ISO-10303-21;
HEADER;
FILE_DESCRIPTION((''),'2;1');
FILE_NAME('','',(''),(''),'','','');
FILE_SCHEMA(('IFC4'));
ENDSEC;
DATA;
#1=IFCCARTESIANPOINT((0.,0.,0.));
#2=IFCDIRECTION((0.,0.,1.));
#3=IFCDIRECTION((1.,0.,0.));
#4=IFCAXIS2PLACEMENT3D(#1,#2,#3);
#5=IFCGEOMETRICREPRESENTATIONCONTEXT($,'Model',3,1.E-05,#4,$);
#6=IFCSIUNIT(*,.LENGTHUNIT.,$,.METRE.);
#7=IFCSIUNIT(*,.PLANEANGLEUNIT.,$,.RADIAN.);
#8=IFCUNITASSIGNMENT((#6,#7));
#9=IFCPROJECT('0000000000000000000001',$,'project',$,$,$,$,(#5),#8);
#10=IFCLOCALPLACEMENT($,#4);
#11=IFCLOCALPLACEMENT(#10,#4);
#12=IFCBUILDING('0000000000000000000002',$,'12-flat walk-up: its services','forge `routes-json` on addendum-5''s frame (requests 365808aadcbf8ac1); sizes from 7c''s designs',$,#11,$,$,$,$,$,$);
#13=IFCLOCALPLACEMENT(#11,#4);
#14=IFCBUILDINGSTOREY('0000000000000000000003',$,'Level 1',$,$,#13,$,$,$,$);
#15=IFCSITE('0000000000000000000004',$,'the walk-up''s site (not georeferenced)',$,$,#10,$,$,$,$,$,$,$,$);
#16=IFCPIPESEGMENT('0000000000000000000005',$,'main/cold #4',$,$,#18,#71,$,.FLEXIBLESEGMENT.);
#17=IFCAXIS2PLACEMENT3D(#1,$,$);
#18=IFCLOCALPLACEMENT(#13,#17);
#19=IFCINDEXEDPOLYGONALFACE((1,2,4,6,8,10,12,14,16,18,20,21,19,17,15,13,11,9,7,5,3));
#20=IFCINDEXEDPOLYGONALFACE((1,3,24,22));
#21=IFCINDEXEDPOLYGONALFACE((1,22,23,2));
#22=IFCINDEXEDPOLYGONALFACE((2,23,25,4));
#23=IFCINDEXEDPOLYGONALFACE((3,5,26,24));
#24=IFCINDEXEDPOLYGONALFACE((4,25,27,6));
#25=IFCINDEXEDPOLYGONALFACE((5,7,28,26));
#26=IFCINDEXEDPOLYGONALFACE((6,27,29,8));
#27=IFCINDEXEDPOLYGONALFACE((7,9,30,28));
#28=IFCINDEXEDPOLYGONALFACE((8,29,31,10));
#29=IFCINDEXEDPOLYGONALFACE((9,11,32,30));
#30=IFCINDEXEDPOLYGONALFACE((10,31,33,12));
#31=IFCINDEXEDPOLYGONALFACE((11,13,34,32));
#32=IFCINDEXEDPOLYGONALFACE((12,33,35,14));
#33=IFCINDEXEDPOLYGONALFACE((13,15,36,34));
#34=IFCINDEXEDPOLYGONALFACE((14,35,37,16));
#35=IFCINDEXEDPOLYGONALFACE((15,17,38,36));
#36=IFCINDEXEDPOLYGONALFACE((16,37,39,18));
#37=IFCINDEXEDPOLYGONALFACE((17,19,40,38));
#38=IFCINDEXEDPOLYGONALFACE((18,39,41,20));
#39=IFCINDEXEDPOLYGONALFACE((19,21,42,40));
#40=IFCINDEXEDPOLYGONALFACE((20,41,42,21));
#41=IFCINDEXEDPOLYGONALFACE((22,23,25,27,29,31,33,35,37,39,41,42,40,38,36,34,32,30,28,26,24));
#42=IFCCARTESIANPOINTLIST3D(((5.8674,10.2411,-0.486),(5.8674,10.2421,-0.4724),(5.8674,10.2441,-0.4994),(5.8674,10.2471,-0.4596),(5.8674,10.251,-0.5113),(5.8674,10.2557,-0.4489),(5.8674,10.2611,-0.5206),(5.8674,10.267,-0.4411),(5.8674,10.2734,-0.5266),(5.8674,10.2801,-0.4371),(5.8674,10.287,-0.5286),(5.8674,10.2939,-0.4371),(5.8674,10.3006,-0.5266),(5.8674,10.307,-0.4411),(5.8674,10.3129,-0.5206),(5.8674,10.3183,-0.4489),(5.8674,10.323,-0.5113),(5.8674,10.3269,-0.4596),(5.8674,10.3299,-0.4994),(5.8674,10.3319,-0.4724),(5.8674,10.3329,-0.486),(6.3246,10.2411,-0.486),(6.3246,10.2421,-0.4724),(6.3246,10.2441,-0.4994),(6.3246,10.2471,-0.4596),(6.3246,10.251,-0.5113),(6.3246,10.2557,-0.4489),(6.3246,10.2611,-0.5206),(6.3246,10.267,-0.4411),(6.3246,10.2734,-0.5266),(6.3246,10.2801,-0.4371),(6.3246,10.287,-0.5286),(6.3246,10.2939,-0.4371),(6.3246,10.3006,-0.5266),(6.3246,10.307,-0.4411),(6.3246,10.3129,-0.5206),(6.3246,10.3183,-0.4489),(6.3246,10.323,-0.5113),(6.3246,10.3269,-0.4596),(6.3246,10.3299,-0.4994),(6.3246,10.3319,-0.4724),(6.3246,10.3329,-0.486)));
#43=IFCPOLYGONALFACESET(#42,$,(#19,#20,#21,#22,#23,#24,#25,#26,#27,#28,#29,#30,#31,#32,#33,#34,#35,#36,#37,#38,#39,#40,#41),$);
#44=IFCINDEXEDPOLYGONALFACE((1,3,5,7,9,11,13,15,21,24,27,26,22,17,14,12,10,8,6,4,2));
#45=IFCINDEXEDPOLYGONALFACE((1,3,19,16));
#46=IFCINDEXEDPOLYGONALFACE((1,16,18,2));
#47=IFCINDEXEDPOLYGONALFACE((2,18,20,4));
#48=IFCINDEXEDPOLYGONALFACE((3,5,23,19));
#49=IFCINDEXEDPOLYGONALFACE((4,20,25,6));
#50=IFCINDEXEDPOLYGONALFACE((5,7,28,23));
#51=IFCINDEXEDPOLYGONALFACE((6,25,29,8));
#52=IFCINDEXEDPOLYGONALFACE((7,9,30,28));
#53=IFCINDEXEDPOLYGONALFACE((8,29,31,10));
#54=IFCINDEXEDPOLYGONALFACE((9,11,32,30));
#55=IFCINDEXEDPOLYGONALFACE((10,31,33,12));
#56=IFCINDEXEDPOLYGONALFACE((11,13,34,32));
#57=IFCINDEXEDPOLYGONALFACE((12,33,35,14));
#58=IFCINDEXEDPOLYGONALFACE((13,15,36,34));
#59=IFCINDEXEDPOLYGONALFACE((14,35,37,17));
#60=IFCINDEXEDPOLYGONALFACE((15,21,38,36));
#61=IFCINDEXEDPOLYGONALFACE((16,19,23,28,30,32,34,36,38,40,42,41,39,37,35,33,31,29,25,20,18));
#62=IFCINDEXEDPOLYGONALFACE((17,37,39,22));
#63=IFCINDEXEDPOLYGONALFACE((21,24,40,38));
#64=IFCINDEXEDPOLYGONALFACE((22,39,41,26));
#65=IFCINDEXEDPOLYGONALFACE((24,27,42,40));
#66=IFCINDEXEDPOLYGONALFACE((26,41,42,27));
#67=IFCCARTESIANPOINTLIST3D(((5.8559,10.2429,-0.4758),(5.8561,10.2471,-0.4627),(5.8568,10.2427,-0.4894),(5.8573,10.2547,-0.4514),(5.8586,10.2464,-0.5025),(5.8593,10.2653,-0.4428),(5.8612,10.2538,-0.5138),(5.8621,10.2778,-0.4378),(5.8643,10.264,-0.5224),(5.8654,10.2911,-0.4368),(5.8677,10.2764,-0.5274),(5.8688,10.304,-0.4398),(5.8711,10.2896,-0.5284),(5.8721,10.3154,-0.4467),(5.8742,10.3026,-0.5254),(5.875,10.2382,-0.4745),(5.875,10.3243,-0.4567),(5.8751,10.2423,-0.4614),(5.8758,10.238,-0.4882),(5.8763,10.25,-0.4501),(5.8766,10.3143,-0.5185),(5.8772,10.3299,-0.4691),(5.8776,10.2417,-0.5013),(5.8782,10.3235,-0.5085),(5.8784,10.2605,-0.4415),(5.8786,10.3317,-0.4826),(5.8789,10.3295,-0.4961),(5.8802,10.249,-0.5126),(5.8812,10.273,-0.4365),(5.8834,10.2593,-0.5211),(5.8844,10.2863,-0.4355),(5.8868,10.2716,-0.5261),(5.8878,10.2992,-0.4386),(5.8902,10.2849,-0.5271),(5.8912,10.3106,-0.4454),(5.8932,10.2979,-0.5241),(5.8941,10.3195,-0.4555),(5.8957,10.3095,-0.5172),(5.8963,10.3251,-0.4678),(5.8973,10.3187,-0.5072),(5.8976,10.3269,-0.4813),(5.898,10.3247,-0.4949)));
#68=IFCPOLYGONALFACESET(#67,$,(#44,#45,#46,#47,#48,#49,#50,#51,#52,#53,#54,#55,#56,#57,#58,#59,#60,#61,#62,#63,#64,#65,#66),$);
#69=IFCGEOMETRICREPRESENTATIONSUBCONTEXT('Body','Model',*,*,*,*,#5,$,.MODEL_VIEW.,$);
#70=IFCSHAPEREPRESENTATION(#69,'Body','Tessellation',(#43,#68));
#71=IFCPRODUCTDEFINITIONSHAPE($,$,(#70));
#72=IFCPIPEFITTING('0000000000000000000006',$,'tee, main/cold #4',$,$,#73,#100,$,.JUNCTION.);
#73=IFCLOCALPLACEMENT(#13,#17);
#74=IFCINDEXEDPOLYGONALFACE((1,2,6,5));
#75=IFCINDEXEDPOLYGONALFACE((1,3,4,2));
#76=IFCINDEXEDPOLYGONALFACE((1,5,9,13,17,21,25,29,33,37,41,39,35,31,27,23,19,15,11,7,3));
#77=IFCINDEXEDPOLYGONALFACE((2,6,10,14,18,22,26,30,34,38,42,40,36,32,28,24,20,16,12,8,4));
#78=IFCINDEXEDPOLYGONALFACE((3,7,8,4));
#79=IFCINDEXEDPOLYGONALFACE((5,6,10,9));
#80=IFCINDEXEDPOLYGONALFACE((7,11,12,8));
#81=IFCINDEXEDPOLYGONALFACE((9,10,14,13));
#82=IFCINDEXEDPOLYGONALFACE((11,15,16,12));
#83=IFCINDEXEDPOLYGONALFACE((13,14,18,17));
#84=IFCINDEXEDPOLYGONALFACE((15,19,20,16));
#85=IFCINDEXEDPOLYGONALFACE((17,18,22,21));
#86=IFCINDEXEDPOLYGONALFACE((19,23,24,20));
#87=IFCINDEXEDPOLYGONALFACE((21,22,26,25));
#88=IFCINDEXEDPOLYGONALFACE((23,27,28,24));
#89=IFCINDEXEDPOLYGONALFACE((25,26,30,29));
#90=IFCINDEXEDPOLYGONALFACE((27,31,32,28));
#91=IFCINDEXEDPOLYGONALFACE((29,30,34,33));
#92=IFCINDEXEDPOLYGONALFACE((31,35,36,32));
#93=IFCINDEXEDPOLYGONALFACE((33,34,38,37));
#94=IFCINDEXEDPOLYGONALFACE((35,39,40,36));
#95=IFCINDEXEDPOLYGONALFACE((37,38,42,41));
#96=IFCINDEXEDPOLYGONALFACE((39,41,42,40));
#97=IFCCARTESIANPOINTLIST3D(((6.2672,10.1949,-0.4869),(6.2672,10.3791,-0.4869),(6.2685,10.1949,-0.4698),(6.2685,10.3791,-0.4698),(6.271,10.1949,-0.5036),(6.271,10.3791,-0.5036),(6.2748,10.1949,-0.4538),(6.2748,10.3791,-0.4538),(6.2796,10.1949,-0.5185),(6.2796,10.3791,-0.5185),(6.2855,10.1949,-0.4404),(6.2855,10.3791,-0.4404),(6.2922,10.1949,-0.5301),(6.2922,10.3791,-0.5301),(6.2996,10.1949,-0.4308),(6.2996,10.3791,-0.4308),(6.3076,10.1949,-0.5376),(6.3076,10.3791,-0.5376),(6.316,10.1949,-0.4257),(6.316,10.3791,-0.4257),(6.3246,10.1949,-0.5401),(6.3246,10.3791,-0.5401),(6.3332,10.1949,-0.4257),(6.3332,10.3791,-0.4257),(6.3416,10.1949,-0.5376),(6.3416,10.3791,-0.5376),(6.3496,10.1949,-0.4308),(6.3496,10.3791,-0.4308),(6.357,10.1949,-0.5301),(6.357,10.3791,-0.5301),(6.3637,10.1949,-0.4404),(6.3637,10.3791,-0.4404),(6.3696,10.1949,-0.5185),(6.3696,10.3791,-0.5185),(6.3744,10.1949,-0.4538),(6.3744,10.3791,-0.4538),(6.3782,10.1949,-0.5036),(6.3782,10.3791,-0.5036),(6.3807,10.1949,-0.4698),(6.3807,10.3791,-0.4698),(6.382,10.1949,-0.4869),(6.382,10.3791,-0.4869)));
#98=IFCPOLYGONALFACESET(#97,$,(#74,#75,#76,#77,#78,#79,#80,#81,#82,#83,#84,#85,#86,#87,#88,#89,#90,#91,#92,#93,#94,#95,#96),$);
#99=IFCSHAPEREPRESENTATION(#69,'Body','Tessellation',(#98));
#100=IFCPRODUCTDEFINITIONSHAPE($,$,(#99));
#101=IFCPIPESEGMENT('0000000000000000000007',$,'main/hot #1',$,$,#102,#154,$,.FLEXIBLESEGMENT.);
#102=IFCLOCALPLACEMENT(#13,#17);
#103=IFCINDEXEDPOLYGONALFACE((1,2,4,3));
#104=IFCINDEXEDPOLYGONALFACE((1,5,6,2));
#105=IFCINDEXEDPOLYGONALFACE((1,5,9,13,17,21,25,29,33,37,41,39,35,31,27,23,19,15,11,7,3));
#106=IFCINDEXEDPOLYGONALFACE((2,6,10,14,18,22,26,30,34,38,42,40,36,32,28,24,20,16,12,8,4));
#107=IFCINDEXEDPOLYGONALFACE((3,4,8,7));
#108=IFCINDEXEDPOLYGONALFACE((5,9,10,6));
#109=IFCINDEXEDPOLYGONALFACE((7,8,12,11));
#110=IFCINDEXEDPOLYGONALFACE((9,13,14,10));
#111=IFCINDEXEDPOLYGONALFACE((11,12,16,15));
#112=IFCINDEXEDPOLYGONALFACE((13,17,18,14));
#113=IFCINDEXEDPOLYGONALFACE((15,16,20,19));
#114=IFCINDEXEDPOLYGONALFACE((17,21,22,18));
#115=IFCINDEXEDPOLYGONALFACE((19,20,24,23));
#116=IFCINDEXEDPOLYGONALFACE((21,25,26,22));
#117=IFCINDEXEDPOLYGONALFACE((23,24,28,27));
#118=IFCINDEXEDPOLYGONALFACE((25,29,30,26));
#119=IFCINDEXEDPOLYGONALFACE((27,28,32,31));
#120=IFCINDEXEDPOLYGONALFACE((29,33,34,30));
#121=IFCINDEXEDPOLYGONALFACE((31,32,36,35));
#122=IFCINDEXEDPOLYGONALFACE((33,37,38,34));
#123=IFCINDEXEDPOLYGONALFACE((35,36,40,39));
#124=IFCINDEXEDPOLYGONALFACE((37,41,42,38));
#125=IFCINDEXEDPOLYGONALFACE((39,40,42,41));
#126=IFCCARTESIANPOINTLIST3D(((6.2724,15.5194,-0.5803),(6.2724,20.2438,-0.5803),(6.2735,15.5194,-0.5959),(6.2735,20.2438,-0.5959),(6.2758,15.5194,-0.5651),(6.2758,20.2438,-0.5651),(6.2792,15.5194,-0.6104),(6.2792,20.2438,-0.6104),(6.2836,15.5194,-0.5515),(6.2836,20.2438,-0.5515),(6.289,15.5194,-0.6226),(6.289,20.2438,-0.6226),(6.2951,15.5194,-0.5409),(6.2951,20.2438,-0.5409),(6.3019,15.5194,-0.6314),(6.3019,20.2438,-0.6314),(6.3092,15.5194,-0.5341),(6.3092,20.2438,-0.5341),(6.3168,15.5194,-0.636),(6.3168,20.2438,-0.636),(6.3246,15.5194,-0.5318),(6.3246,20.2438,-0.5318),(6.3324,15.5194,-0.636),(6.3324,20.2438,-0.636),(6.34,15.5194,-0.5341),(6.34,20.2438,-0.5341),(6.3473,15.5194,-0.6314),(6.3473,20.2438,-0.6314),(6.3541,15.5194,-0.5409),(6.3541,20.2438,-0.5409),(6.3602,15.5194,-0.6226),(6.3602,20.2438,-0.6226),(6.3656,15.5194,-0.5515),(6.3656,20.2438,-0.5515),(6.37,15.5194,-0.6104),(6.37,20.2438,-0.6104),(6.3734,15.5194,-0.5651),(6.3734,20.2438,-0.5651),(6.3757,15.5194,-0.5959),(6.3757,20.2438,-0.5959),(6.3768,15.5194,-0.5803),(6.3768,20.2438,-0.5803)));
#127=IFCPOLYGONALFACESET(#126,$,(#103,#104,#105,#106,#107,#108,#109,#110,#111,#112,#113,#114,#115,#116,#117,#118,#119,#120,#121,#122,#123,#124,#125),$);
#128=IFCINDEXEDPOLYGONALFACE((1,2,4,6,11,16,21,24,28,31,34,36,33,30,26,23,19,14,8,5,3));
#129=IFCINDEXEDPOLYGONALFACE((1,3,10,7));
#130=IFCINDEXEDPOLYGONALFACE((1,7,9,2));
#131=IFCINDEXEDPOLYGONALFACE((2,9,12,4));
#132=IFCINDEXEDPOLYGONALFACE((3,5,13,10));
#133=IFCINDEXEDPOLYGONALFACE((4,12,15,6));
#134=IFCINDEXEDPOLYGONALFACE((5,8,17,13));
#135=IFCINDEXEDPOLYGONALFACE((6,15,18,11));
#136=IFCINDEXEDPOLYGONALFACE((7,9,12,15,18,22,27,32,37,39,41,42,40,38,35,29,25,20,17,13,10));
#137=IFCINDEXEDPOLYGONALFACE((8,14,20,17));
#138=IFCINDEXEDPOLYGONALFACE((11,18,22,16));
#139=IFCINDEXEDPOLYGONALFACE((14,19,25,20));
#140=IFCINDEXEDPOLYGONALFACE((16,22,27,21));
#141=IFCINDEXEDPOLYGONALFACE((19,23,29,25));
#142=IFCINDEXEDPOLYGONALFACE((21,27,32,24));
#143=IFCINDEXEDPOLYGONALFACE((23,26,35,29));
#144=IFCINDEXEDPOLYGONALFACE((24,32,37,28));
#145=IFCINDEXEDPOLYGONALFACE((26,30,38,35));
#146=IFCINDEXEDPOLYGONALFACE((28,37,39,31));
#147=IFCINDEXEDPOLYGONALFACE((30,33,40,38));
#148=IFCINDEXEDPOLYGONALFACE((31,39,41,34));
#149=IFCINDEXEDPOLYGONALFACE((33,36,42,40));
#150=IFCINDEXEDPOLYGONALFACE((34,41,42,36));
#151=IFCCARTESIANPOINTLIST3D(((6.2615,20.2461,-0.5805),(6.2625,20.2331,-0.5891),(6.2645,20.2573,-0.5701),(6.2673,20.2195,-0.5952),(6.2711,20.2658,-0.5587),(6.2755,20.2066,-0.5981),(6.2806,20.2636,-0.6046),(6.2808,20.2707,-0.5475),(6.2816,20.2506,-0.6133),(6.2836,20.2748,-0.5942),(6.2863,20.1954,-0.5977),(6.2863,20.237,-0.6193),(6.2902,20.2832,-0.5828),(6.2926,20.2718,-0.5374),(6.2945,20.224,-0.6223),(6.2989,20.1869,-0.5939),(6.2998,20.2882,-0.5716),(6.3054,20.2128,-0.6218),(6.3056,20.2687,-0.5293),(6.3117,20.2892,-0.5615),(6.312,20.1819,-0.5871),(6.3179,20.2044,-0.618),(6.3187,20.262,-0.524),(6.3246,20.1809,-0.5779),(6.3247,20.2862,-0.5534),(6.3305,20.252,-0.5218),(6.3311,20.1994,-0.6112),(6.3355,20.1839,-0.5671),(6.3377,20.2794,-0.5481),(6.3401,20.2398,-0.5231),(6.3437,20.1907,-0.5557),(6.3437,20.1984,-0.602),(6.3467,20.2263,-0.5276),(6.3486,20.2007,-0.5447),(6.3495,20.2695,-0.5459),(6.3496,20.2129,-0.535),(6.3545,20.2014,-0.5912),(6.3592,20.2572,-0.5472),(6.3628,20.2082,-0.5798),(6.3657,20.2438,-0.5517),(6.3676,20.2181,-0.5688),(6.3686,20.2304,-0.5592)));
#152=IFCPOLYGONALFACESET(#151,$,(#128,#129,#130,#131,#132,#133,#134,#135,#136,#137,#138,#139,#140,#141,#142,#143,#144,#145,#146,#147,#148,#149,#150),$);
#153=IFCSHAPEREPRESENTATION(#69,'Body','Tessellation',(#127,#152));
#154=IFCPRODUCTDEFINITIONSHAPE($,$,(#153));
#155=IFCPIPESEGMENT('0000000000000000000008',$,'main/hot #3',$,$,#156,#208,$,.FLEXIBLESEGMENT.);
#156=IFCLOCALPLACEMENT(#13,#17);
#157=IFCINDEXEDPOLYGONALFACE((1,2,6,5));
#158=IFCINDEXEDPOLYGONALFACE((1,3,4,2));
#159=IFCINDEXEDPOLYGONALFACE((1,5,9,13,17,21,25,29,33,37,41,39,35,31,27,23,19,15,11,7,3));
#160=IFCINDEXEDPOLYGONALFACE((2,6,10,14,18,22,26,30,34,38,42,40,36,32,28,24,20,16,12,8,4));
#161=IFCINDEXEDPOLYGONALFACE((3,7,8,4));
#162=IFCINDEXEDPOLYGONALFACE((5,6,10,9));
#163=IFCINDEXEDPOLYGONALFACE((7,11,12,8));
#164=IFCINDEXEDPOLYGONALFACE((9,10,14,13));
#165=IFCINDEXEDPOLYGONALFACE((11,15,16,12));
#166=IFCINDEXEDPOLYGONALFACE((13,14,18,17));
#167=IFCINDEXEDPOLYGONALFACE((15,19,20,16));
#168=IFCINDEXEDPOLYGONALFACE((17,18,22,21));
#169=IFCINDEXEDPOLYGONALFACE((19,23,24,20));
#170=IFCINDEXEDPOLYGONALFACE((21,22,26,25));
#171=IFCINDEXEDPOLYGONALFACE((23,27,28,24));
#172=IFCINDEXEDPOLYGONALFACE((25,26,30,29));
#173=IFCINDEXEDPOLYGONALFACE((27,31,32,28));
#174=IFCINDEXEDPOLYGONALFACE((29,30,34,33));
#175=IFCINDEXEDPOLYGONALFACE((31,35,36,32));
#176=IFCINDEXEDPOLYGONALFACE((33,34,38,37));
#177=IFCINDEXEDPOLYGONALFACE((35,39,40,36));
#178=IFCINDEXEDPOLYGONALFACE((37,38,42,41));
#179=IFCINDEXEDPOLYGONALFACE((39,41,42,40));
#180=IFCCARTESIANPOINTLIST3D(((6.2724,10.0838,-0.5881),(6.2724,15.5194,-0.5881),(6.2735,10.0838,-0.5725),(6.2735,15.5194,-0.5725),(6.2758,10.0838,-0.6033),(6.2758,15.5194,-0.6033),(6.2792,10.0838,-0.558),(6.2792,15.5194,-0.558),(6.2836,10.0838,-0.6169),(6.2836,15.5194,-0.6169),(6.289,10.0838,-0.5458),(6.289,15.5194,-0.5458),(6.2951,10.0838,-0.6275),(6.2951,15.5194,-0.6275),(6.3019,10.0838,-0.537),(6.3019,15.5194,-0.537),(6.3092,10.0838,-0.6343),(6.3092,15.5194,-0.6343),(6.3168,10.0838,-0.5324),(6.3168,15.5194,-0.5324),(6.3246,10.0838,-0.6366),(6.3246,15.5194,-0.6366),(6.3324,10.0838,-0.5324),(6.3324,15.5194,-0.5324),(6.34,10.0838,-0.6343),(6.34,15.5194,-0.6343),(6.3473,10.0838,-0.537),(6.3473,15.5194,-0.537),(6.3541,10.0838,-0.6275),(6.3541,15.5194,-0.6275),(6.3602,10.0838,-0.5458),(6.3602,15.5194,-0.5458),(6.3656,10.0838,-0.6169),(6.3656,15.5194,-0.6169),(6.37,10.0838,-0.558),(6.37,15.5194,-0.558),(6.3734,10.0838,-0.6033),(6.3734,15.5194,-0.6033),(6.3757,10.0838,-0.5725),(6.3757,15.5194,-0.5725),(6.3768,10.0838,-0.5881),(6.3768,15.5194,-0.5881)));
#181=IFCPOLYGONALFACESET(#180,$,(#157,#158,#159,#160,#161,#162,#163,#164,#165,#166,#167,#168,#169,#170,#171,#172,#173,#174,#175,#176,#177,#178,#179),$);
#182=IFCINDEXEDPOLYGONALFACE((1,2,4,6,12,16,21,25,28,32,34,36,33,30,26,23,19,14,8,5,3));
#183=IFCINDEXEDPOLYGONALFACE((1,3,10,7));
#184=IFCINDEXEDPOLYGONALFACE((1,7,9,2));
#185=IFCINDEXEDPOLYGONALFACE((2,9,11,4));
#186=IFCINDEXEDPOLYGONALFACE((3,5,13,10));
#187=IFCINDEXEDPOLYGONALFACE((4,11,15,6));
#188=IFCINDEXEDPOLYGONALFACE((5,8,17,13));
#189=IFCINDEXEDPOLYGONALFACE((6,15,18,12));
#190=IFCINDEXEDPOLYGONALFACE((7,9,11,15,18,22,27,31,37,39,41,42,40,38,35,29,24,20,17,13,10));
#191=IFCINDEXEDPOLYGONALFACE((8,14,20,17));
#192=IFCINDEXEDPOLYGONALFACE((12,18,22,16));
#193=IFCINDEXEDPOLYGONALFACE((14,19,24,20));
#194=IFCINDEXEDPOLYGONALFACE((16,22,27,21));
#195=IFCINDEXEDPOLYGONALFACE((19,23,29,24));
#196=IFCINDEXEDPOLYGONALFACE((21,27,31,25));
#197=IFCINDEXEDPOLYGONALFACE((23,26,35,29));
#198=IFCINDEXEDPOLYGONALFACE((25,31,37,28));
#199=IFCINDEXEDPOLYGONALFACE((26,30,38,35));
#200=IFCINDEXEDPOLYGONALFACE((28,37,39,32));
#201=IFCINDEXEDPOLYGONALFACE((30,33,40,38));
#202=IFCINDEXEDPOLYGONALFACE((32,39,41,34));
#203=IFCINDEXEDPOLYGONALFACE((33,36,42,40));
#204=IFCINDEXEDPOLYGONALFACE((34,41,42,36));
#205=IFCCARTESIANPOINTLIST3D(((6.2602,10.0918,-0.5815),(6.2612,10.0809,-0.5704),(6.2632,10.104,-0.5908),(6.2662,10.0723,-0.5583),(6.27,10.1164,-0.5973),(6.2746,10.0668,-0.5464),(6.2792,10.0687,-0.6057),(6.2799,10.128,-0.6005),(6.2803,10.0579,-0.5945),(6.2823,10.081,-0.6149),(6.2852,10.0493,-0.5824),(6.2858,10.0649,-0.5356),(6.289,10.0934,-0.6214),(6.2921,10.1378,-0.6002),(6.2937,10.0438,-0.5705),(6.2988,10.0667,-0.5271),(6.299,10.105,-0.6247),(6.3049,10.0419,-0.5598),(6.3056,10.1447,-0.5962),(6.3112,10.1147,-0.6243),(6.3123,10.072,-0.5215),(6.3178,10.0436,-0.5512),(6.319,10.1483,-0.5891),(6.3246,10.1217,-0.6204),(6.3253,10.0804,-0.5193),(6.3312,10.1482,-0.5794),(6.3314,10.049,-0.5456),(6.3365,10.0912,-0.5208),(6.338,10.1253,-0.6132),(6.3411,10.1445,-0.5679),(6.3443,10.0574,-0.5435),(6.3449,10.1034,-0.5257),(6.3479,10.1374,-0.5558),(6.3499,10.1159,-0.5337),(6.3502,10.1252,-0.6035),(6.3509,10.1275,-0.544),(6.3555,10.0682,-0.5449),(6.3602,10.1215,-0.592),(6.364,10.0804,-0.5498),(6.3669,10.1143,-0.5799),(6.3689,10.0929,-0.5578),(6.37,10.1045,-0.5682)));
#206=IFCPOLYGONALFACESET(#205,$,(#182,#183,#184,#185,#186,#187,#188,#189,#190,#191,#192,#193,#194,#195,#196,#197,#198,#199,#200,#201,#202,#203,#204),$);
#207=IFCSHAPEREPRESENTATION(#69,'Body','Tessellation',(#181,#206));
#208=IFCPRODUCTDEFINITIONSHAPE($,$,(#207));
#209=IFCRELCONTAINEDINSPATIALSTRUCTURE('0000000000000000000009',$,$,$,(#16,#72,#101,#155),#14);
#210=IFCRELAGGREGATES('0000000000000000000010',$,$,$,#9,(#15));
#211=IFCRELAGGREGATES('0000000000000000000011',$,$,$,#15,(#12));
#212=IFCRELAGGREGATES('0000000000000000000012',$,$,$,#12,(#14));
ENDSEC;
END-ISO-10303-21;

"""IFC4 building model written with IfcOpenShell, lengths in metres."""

from ifc_helpers import new_model, entity, si_unit, frame, origin_with_axes, place, context, subcontext, project, spatial, element, save


model = new_model("IFC4")

# Units and contexts
model_context = context("Model", 3, precision=1e-05, world=origin_with_axes())
body_context = subcontext(model_context, "Body", "Model", "MODEL_VIEW")
ifc_project = project(units=[si_unit("LENGTHUNIT", "METRE"), si_unit("PLANEANGLEUNIT", "RADIAN")], contexts=[model_context])

# Site, building, storey
site_placement = place(None, origin_with_axes())
site = spatial("IfcSite", under=ifc_project, at=site_placement, Name="the walk-up's site (not georeferenced)")
building_placement = place(site_placement, origin_with_axes())
building = spatial("IfcBuilding", under=site, at=building_placement, Name="12-flat walk-up: its services", Description="forge `routes-json` on addendum-5's frame (requests 365808aadcbf8ac1); sizes from 7c's designs")
storey_placement = place(building_placement, origin_with_axes())
storey = spatial("IfcBuildingStorey", under=building, at=storey_placement, Name="Level 1")

# Pipe segment
pipe_segment_1_placement = place(storey_placement, frame((6.3246, 10.287, -0.4826), z_axis=(0.0, 0.0, 1.0), x_axis=(1.0, 0.0, 0.0)))
element("IfcPipeSegment", 1, at=pipe_segment_1_placement, inside=storey, Name="main/cold #4", PredefinedType="FLEXIBLESEGMENT", context=body_context, shape_type="AdvancedSweptSolid", body=[
    entity("IfcSweptDiskSolid", entity("IfcPolyline", [entity("IfcCartesianPoint", [0.0, 0.0, 0.0]), entity("IfcCartesianPoint", [-0.4572, 0.0, 0.0])]), 0.046),
    entity("IfcSweptDiskSolid", entity("IfcPolyline", [entity("IfcCartesianPoint", [-0.4572, 0.0, 0.0]), entity("IfcCartesianPoint", [-0.4381, -0.0048, 0.0013])]), 0.046),
])

# Pipe fitting
pipe_fitting_1_placement = place(storey_placement, frame((6.3246, 10.3791, -0.4826), z_axis=(0.0, 0.0, 1.0), x_axis=(1.0, 0.0, 0.0)))
element("IfcPipeFitting", 2, at=pipe_fitting_1_placement, inside=storey, Name="tee, main/cold #4", PredefinedType="JUNCTION", context=body_context, shape_type="AdvancedSweptSolid", body=[
    entity("IfcSweptDiskSolid", entity("IfcPolyline", [entity("IfcCartesianPoint", [0.0, 0.0, 0.0]), entity("IfcCartesianPoint", [0.0, -0.1841, 0.0])]), 0.0575),
])

# Pipe segments
pipe_segment_2_placement = place(storey_placement, frame((6.3246, 15.5194, -0.5842), z_axis=(0.0, 0.0, 1.0), x_axis=(1.0, 0.0, 0.0)))
element("IfcPipeSegment", 3, at=pipe_segment_2_placement, inside=storey, Name="main/hot #1", PredefinedType="FLEXIBLESEGMENT", context=body_context, shape_type="AdvancedSweptSolid", body=[
    entity("IfcSweptDiskSolid", entity("IfcPolyline", [entity("IfcCartesianPoint", [0.0, 0.0, 0.0]), entity("IfcCartesianPoint", [0.0, 4.7244, 0.0])]), 0.0524),
    entity("IfcSweptDiskSolid", entity("IfcPolyline", [entity("IfcCartesianPoint", [0.0, 4.7244, 0.0]), entity("IfcCartesianPoint", [-0.019, 4.7069, 0.0241])]), 0.0524),
])
pipe_segment_3_placement = place(storey_placement, frame((6.3246, 15.5194, -0.5842), z_axis=(0.0, 0.0, 1.0), x_axis=(1.0, 0.0, 0.0)))
element("IfcPipeSegment", 4, at=pipe_segment_3_placement, inside=storey, Name="main/hot #3", PredefinedType="FLEXIBLESEGMENT", context=body_context, shape_type="AdvancedSweptSolid", body=[
    entity("IfcSweptDiskSolid", entity("IfcPolyline", [entity("IfcCartesianPoint", [0.0, 0.0, 0.0]), entity("IfcCartesianPoint", [0.0, -5.4356, 0.0])]), 0.0524),
    entity("IfcSweptDiskSolid", entity("IfcPolyline", [entity("IfcCartesianPoint", [0.0, -5.4356, 0.0]), entity("IfcCartesianPoint", [-0.019, -5.4126, 0.0241])]), 0.0524),
])

save(model, "model.ifc")
